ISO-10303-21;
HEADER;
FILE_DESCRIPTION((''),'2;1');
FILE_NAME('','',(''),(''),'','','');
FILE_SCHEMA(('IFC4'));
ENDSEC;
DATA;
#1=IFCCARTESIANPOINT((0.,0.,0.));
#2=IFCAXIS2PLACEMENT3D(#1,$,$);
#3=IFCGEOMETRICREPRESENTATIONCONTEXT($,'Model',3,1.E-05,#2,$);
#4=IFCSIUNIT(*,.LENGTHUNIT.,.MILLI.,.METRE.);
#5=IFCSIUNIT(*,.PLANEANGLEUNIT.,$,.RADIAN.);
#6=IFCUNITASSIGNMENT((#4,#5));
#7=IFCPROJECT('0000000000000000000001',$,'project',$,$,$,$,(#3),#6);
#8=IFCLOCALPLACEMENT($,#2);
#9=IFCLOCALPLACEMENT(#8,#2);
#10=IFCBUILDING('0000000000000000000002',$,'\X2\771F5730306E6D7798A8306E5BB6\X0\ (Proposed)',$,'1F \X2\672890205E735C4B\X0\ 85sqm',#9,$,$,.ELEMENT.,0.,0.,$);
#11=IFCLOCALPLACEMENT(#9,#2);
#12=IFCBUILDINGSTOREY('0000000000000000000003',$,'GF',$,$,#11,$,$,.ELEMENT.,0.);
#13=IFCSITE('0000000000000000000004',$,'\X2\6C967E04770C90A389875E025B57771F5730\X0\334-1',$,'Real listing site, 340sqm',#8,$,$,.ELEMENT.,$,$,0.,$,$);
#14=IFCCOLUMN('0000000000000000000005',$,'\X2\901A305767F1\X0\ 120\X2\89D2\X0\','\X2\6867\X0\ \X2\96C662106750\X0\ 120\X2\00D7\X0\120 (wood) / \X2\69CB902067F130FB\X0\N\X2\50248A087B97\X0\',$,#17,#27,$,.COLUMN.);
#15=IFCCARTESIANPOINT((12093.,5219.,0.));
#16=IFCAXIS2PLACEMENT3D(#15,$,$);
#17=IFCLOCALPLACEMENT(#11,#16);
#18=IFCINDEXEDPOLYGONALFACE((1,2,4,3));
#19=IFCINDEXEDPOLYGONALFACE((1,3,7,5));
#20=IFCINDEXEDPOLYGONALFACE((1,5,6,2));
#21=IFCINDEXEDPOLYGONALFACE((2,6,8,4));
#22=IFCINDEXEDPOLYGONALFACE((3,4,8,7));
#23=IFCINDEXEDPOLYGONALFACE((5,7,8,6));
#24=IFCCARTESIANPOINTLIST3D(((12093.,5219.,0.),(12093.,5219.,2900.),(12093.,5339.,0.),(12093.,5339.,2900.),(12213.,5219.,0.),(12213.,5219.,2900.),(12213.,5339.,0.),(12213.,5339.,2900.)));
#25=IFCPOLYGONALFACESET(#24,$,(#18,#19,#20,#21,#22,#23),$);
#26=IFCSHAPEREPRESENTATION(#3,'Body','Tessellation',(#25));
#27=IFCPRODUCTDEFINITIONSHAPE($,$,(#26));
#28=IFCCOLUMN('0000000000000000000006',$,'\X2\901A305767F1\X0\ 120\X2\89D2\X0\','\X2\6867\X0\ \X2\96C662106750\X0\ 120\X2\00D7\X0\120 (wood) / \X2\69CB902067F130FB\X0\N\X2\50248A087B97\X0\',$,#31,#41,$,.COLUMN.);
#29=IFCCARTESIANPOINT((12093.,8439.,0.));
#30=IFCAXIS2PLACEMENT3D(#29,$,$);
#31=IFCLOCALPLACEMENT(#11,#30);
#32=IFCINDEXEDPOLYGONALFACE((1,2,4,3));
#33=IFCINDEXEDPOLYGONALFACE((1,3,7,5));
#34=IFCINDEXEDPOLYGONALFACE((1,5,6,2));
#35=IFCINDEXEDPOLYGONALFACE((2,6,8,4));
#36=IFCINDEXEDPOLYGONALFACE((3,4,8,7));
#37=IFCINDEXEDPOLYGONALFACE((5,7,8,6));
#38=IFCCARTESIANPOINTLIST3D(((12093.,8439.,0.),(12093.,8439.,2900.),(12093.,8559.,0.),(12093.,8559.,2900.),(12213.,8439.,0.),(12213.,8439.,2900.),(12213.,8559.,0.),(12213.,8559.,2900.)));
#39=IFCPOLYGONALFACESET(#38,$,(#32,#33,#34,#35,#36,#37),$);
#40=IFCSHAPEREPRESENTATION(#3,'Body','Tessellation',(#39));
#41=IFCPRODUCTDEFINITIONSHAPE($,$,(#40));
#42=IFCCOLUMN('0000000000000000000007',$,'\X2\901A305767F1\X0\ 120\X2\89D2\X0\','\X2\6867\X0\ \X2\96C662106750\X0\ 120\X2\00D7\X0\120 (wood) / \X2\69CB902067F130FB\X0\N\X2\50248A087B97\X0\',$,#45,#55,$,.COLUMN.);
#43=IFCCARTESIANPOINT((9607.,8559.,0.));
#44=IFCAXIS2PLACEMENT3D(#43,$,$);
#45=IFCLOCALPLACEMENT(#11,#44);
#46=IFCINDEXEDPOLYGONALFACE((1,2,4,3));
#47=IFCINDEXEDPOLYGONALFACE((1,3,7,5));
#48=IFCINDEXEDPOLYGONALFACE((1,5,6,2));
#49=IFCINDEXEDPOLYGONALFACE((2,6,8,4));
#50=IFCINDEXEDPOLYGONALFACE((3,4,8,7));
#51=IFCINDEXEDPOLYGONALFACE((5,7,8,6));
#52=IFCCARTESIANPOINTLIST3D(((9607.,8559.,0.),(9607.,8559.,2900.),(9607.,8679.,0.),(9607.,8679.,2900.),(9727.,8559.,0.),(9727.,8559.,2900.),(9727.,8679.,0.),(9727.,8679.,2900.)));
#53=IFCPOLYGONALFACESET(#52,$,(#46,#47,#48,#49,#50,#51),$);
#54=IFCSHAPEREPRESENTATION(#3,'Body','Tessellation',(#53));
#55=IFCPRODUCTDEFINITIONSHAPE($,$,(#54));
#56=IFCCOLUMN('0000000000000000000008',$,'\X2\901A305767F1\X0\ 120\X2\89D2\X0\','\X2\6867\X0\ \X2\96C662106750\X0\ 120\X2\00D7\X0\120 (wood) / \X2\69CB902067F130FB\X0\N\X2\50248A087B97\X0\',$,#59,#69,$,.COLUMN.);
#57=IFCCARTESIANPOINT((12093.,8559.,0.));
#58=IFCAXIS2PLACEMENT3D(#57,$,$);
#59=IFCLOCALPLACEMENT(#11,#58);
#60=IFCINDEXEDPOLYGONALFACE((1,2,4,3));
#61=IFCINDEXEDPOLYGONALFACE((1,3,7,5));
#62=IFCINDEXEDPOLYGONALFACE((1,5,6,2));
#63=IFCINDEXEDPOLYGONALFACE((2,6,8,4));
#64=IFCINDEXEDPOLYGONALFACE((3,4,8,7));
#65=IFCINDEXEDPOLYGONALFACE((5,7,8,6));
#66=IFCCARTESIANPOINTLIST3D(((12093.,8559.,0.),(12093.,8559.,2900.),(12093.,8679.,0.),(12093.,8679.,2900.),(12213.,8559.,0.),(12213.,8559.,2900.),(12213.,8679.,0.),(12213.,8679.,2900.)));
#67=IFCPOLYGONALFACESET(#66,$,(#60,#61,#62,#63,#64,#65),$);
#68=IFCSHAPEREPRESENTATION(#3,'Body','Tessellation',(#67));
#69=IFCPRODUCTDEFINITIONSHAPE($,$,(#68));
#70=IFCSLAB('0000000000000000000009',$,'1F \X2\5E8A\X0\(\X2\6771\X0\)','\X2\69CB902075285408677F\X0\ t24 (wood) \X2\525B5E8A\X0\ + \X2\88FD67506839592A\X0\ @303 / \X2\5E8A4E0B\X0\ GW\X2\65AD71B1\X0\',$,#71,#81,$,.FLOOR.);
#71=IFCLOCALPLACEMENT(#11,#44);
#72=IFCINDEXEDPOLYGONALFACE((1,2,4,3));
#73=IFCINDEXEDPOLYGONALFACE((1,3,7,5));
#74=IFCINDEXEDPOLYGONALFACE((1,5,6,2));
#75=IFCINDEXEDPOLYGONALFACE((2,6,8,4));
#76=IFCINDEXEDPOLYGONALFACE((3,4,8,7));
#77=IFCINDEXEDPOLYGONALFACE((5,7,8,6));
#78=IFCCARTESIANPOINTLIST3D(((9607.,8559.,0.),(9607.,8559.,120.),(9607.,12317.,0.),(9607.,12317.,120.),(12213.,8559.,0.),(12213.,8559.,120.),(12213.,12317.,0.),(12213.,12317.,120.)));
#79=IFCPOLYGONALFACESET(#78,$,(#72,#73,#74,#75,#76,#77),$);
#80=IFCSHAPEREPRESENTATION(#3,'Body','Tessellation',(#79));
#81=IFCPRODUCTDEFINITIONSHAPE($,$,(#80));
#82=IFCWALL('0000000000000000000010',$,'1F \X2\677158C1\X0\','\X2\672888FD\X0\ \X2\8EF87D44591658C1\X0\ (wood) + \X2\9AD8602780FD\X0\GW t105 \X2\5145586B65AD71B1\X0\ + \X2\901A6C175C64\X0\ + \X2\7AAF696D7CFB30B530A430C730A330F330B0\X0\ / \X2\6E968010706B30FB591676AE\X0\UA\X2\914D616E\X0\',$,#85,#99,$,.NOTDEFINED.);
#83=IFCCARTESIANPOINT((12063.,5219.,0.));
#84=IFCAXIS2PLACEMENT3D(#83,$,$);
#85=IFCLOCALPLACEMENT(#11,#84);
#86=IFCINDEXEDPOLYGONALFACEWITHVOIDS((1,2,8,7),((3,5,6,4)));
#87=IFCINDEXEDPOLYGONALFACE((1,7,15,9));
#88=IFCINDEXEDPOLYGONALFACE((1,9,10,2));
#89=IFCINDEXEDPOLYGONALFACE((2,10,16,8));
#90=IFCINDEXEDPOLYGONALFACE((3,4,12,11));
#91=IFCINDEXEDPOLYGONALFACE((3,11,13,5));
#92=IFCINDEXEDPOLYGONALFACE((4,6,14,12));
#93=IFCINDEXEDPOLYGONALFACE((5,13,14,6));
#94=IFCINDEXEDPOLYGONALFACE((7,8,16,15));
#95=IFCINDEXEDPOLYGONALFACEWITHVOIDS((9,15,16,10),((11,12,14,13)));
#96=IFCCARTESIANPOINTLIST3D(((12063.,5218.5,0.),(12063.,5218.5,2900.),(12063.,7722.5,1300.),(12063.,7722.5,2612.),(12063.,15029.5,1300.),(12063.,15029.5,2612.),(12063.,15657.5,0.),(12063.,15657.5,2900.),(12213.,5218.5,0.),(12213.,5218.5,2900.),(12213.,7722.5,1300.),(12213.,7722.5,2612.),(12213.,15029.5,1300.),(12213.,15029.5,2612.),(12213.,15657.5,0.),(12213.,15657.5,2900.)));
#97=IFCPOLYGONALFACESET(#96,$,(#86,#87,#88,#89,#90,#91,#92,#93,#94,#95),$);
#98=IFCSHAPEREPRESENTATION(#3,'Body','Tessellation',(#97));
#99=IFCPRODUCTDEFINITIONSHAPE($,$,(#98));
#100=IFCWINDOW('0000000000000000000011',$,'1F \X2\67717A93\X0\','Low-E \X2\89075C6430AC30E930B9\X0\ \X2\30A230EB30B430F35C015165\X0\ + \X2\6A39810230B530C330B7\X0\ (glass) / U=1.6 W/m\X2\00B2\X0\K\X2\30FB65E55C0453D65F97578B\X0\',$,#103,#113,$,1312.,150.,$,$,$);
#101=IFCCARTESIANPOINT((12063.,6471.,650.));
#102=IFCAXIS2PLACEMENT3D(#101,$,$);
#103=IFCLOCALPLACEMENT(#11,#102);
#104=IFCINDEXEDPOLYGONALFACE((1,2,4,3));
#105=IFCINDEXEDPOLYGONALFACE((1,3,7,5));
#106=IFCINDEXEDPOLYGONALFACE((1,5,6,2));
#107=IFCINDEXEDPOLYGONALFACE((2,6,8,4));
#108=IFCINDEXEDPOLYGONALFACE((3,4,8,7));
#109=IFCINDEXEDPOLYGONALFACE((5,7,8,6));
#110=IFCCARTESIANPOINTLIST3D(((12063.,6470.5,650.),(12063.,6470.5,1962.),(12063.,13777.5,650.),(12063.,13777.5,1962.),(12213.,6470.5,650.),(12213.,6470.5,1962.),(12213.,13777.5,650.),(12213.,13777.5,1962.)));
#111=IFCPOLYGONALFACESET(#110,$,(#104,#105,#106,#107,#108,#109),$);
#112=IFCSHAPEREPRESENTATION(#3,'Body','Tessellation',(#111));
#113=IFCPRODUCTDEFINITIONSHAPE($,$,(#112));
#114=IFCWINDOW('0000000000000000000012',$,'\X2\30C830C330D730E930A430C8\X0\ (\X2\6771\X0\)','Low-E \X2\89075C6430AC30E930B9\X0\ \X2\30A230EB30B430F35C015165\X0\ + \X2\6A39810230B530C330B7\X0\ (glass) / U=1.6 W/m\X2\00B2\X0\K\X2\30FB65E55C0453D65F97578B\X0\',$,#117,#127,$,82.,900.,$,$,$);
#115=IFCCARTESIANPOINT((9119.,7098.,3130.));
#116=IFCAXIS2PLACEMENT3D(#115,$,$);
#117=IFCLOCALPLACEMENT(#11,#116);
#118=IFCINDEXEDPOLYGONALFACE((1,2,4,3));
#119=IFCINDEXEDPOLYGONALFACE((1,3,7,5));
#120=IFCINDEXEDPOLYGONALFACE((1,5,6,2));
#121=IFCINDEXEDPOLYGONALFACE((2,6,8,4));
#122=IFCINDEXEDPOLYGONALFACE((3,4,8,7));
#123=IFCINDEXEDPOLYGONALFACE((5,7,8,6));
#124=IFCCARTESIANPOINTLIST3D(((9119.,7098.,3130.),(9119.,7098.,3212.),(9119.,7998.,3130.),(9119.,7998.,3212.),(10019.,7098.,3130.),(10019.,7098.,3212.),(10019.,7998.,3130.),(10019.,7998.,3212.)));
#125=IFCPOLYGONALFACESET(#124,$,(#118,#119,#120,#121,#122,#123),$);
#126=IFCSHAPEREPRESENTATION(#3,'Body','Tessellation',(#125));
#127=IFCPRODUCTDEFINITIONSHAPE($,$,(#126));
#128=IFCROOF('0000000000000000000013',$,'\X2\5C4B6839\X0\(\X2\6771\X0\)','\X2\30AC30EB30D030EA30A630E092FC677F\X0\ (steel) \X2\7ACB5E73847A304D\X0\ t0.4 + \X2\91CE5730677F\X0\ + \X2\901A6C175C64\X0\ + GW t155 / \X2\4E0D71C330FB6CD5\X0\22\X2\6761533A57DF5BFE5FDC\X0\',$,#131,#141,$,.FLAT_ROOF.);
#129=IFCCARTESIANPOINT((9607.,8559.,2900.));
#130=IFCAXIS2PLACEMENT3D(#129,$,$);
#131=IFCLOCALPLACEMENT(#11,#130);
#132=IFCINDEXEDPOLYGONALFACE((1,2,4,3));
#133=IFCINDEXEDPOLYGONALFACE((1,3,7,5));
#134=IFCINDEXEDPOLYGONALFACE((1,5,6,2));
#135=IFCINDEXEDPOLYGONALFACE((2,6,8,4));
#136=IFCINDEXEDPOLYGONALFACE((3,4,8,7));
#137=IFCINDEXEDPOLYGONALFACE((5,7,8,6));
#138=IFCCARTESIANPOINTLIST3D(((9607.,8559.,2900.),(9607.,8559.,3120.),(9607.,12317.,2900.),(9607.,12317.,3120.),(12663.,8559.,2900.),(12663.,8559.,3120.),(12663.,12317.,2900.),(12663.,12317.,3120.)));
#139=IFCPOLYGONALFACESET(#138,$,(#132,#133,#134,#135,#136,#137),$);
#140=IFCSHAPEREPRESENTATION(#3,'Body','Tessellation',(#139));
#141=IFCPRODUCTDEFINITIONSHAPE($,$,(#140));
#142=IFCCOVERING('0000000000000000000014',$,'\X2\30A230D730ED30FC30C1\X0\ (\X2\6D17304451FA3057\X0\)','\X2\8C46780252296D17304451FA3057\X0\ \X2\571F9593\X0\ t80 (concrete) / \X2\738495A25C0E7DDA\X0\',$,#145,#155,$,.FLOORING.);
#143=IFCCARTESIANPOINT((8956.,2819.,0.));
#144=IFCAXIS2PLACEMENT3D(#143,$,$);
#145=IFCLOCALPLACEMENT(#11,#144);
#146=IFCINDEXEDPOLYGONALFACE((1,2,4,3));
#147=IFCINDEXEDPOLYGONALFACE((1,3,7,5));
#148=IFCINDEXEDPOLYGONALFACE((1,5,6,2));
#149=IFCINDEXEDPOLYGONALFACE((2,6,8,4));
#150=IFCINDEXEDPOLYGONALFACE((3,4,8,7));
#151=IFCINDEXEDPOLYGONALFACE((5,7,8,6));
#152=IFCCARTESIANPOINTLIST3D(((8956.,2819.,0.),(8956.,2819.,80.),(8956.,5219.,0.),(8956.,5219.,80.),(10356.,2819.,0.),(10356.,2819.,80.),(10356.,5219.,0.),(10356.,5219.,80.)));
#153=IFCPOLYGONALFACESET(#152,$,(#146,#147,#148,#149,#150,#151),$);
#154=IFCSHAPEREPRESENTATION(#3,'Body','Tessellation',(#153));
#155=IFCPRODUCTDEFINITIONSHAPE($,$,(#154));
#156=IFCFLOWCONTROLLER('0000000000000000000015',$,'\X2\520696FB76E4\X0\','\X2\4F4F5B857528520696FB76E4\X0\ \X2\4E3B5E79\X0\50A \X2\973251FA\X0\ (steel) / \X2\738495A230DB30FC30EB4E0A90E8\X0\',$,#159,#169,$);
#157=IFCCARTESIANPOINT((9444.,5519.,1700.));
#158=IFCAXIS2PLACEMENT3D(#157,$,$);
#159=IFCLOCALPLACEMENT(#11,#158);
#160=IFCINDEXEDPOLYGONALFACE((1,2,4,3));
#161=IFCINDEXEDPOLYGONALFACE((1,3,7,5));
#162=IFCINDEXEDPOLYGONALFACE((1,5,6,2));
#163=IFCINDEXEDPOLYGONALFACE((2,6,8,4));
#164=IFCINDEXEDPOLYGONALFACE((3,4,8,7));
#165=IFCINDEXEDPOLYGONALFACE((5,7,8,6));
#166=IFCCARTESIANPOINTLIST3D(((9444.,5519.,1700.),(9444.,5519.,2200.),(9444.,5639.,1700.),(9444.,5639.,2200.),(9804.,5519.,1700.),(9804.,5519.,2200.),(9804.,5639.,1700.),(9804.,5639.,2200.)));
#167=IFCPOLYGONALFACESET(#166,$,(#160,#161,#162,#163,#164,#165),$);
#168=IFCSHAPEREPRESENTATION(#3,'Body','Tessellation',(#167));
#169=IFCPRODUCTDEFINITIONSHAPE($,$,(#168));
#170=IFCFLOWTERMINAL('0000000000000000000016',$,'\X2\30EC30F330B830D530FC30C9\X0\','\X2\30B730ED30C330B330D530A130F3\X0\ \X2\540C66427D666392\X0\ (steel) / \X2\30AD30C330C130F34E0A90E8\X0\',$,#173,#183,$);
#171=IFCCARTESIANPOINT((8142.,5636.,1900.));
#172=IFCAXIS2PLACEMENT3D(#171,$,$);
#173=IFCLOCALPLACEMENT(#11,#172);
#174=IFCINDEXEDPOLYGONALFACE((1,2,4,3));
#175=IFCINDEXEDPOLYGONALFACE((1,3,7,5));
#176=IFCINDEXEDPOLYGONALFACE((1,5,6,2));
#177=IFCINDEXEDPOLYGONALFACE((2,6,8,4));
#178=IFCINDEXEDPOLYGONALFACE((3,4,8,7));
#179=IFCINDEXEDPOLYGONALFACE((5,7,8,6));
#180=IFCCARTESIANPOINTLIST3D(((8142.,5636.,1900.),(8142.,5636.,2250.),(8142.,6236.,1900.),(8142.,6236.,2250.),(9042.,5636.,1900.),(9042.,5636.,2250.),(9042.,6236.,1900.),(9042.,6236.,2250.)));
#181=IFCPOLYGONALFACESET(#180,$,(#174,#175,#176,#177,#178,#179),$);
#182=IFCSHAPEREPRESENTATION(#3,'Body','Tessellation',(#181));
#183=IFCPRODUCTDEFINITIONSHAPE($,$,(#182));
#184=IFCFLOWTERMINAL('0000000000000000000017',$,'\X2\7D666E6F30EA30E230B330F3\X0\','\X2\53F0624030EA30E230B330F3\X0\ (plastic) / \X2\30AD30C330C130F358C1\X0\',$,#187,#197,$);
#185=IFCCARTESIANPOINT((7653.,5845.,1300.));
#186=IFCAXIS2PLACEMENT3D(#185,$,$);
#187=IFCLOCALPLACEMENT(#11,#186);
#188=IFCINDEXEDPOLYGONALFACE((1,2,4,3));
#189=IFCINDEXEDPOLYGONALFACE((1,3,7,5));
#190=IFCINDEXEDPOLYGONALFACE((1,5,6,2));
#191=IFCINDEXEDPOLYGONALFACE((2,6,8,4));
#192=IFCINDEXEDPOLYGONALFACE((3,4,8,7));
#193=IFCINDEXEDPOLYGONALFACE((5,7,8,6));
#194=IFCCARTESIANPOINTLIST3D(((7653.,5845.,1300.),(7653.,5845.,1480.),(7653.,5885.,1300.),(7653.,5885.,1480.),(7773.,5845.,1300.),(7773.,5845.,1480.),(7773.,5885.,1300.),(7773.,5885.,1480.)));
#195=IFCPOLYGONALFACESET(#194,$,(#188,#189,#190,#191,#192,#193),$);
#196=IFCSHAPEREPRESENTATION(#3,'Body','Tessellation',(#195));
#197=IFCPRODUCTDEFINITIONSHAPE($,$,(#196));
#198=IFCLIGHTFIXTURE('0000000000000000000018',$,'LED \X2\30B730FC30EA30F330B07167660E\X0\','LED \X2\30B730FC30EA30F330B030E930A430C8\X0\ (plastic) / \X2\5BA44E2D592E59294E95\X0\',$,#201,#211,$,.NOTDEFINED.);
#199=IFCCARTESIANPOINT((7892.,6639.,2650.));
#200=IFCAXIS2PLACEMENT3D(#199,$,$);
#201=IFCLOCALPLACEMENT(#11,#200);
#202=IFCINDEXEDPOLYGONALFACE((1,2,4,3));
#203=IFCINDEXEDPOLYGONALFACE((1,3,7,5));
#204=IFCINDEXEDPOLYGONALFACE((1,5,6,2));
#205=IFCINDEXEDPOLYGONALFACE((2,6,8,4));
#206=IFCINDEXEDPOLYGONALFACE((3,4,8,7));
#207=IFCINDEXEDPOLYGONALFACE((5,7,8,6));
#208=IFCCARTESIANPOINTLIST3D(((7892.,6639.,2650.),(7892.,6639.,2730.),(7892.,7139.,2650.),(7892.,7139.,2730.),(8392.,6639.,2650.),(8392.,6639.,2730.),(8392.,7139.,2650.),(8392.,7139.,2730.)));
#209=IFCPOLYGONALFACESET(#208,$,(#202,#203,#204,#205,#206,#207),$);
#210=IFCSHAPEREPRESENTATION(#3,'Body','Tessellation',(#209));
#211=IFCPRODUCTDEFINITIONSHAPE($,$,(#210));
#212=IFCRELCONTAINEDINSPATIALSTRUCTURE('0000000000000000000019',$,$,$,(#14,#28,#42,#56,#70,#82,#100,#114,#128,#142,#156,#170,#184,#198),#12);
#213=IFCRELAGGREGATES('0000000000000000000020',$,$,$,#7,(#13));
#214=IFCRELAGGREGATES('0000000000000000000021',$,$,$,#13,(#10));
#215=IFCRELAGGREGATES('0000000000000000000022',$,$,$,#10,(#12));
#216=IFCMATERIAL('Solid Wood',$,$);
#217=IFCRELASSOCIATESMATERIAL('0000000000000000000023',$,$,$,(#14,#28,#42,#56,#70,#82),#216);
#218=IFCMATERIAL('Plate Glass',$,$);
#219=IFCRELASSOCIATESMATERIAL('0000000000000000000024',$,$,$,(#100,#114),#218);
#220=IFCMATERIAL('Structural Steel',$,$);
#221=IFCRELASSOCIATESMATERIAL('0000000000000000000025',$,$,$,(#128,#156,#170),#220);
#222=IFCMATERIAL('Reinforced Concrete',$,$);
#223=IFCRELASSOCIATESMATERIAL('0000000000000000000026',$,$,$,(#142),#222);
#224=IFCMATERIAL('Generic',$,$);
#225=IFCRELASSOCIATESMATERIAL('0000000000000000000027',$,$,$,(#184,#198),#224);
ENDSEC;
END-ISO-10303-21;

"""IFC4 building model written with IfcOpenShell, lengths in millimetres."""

from ifc_helpers import new_model, si_unit, frame, frame_2d, origin, place, context, project, spatial, rectangle, extrude, material, element, fill, save


model = new_model("IFC4")

# Units and contexts
model_context = context("Model", 3, precision=1e-05, world=origin())
ifc_project = project(units=[si_unit("LENGTHUNIT", "METRE", prefix="MILLI"), si_unit("PLANEANGLEUNIT", "RADIAN")], contexts=[model_context])

# Site, building, storey
site_placement = place(None, origin())
site = spatial("IfcSite", under=ifc_project, at=site_placement, Name="沖縄県那覇市字真地334-1", ObjectType="Real listing site, 340sqm", CompositionType="ELEMENT", RefElevation=0.0)
building_placement = place(site_placement, origin())
building = spatial("IfcBuilding", under=site, at=building_placement, Name="真地の海風の家 (Proposed)", ObjectType="1F 木造平屋 85sqm", CompositionType="ELEMENT", ElevationOfRefHeight=0.0, ElevationOfTerrain=0.0)
storey_placement = place(building_placement, origin())
storey = spatial("IfcBuildingStorey", under=building, at=storey_placement, Name="GF", CompositionType="ELEMENT", Elevation=0.0)

# Columns
ifc_material_1 = material(Name="Solid Wood")
column_1_placement = place(storey_placement, frame((12093.0, 5219.0, 0.0)))
element("IfcColumn", 1, at=column_1_placement, inside=storey, material=ifc_material_1, Name="通し柱 120角", Description="桧 集成材 120×120 (wood) / 構造柱・N値計算", PredefinedType="COLUMN", context=model_context, shape_type="SweptSolid", body=[
    extrude(rectangle(XDim=120.0, YDim=120.0, at=frame_2d((60.0, 60.0))), frame((12093.0, 5219.0, 0.0)), (0.0, 0.0, 1.0), 2900.0),
])
column_2_placement = place(storey_placement, frame((12093.0, 8439.0, 0.0)))
element("IfcColumn", 2, at=column_2_placement, inside=storey, material=ifc_material_1, Name="通し柱 120角", Description="桧 集成材 120×120 (wood) / 構造柱・N値計算", PredefinedType="COLUMN", context=model_context, shape_type="SweptSolid", body=[
    extrude(rectangle(XDim=120.0, YDim=120.0, at=frame_2d((60.0, 60.0))), frame((12093.0, 8439.0, 0.0)), (0.0, 0.0, 1.0), 2900.0),
])
column_3_placement = place(storey_placement, frame((9607.0, 8559.0, 0.0)))
element("IfcColumn", 3, at=column_3_placement, inside=storey, material=ifc_material_1, Name="通し柱 120角", Description="桧 集成材 120×120 (wood) / 構造柱・N値計算", PredefinedType="COLUMN", context=model_context, shape_type="SweptSolid", body=[
    extrude(rectangle(XDim=120.0, YDim=120.0, at=frame_2d((60.0, 60.0))), frame((9607.0, 8559.0, 0.0)), (0.0, 0.0, 1.0), 2900.0),
])
column_4_placement = place(storey_placement, frame((12093.0, 8559.0, 0.0)))
element("IfcColumn", 4, at=column_4_placement, inside=storey, material=ifc_material_1, Name="通し柱 120角", Description="桧 集成材 120×120 (wood) / 構造柱・N値計算", PredefinedType="COLUMN", context=model_context, shape_type="SweptSolid", body=[
    extrude(rectangle(XDim=120.0, YDim=120.0, at=frame_2d((60.0, 60.0))), frame((12093.0, 8559.0, 0.0)), (0.0, 0.0, 1.0), 2900.0),
])

# Slab
slab_placement = place(storey_placement, frame((9607.0, 8559.0, 0.0)))
element("IfcSlab", 5, at=slab_placement, inside=storey, material=ifc_material_1, Name="1F 床(東)", Description="構造用合板 t24 (wood) 剛床 + 製材根太 @303 / 床下 GW断熱", PredefinedType="FLOOR", context=model_context, shape_type="SweptSolid", body=[
    extrude(rectangle(XDim=2606.0, YDim=3758.0, at=frame_2d((1303.0, 1879.0))), frame((9607.0, 8559.0, 0.0)), (0.0, 0.0, 1.0), 120.0),
])

# Wall, opening, window
wall_1_placement = place(storey_placement, frame((12063.0, 5219.0, 0.0)))
wall_1 = element("IfcWall", 6, at=wall_1_placement, inside=storey, material=ifc_material_1, Name="1F 東壁", Description="木製 軸組外壁 (wood) + 高性能GW t105 充填断熱 + 通気層 + 窯業系サイディング / 準耐火・外皮UA配慮", PredefinedType="NOTDEFINED", context=model_context, shape_type="SweptSolid", body=[
    extrude(rectangle(XDim=150.0, YDim=10439.0, at=frame_2d((75.0, 5219.0))), frame((12063.0, 5219.0, 0.0)), (0.0, 0.0, 1.0), 2900.0),
])
opening_placement = place(storey_placement, frame((12063.0, 6471.0, 650.0)))
opening = element("IfcOpeningElement", 7, at=opening_placement, cuts=wall_1, PredefinedType="NOTDEFINED", context=model_context, shape_type="SweptSolid", body=[
    extrude(rectangle(XDim=150.0, YDim=7307.0, at=frame_2d((75.0, 3653.0))), frame((12063.0, 6471.0, 650.0)), (0.0, 0.0, 1.0), 1312.0),
])
ifc_material_2 = material(Name="Plate Glass")
window_1_placement = place(storey_placement, frame((12063.0, 6471.0, 650.0)))
window_1 = element("IfcWindow", 8, at=window_1_placement, inside=storey, material=ifc_material_2, Name="1F 東窓", Description="Low-E 複層ガラス アルゴン封入 + 樹脂サッシ (glass) / U=1.6 W/m²K・日射取得型", OverallHeight=1312.0, OverallWidth=150.0, context=model_context, shape_type="SweptSolid", body=[
    extrude(rectangle(XDim=150.0, YDim=7307.0, at=frame_2d((75.0, 3653.0))), frame((12063.0, 6471.0, 650.0)), (0.0, 0.0, 1.0), 1312.0),
])
fill(opening, window_1)

# Window
window_2_placement = place(storey_placement, frame((9119.0, 7098.0, 3130.0)))
element("IfcWindow", 9, at=window_2_placement, inside=storey, material=ifc_material_2, Name="トップライト (東)", Description="Low-E 複層ガラス アルゴン封入 + 樹脂サッシ (glass) / U=1.6 W/m²K・日射取得型", OverallHeight=82.0, OverallWidth=900.0, context=model_context, shape_type="SweptSolid", body=[
    extrude(rectangle(XDim=900.0, YDim=900.0, at=frame_2d((450.0, 450.0))), frame((9119.0, 7098.0, 3130.0)), (0.0, 0.0, 1.0), 82.0),
])

# Roof
ifc_material_3 = material(Name="Structural Steel")
roof_placement = place(storey_placement, frame((9607.0, 8559.0, 2900.0)))
element("IfcRoof", 10, at=roof_placement, inside=storey, material=ifc_material_3, Name="屋根(東)", Description="ガルバリウム鋼板 (steel) 立平葺き t0.4 + 野地板 + 通気層 + GW t155 / 不燃・法22条区域対応", PredefinedType="FLAT_ROOF", context=model_context, shape_type="SweptSolid", body=[
    extrude(rectangle(XDim=3056.0, YDim=3758.0, at=frame_2d((1528.0, 1879.0))), frame((9607.0, 8559.0, 2900.0)), (0.0, 0.0, 1.0), 220.0),
])

# Covering
ifc_material_4 = material(Name="Reinforced Concrete")
covering_placement = place(storey_placement, frame((8956.0, 2819.0, 0.0)))
element("IfcCovering", 11, at=covering_placement, inside=storey, material=ifc_material_4, Name="アプローチ (洗い出し)", Description="豆砂利洗い出し 土間 t80 (concrete) / 玄関導線", PredefinedType="FLOORING", context=model_context, shape_type="SweptSolid", body=[
    extrude(rectangle(XDim=1400.0, YDim=2400.0, at=frame_2d((700.0, 1200.0))), frame((8956.0, 2819.0, 0.0)), (0.0, 0.0, 1.0), 80.0),
])

# Flow controller
flow_controller_placement = place(storey_placement, frame((9444.0, 5519.0, 1700.0)))
element("IfcFlowController", 12, at=flow_controller_placement, inside=storey, material=ifc_material_3, Name="分電盤", Description="住宅用分電盤 主幹50A 露出 (steel) / 玄関ホール上部", context=model_context, shape_type="SweptSolid", body=[
    extrude(rectangle(XDim=360.0, YDim=120.0, at=frame_2d((180.0, 60.0))), frame((9444.0, 5519.0, 1700.0)), (0.0, 0.0, 1.0), 500.0),
])

# Flow terminals
flow_terminal_1_placement = place(storey_placement, frame((8142.0, 5636.0, 1900.0)))
element("IfcFlowTerminal", 13, at=flow_terminal_1_placement, inside=storey, material=ifc_material_3, Name="レンジフード", Description="シロッコファン 同時給排 (steel) / キッチン上部", context=model_context, shape_type="SweptSolid", body=[
    extrude(rectangle(XDim=900.0, YDim=600.0, at=frame_2d((450.0, 300.0))), frame((8142.0, 5636.0, 1900.0)), (0.0, 0.0, 1.0), 350.0),
])
ifc_material_5 = material(Name="Generic")
flow_terminal_2_placement = place(storey_placement, frame((7653.0, 5845.0, 1300.0)))
element("IfcFlowTerminal", 14, at=flow_terminal_2_placement, inside=storey, material=ifc_material_5, Name="給湯リモコン", Description="台所リモコン (plastic) / キッチン壁", context=model_context, shape_type="SweptSolid", body=[
    extrude(rectangle(XDim=120.0, YDim=40.0, at=frame_2d((60.0, 20.0))), frame((7653.0, 5845.0, 1300.0)), (0.0, 0.0, 1.0), 180.0),
])

# Light fixture
light_fixture_placement = place(storey_placement, frame((7892.0, 6639.0, 2650.0)))
element("IfcLightFixture", 15, at=light_fixture_placement, inside=storey, material=ifc_material_5, Name="LED シーリング照明", Description="LED シーリングライト (plastic) / 室中央天井", PredefinedType="NOTDEFINED", context=model_context, shape_type="SweptSolid", body=[
    extrude(rectangle(XDim=500.0, YDim=500.0, at=frame_2d((250.0, 250.0))), frame((7892.0, 6639.0, 2650.0)), (0.0, 0.0, 1.0), 80.0),
])

save(model, "model.ifc")
